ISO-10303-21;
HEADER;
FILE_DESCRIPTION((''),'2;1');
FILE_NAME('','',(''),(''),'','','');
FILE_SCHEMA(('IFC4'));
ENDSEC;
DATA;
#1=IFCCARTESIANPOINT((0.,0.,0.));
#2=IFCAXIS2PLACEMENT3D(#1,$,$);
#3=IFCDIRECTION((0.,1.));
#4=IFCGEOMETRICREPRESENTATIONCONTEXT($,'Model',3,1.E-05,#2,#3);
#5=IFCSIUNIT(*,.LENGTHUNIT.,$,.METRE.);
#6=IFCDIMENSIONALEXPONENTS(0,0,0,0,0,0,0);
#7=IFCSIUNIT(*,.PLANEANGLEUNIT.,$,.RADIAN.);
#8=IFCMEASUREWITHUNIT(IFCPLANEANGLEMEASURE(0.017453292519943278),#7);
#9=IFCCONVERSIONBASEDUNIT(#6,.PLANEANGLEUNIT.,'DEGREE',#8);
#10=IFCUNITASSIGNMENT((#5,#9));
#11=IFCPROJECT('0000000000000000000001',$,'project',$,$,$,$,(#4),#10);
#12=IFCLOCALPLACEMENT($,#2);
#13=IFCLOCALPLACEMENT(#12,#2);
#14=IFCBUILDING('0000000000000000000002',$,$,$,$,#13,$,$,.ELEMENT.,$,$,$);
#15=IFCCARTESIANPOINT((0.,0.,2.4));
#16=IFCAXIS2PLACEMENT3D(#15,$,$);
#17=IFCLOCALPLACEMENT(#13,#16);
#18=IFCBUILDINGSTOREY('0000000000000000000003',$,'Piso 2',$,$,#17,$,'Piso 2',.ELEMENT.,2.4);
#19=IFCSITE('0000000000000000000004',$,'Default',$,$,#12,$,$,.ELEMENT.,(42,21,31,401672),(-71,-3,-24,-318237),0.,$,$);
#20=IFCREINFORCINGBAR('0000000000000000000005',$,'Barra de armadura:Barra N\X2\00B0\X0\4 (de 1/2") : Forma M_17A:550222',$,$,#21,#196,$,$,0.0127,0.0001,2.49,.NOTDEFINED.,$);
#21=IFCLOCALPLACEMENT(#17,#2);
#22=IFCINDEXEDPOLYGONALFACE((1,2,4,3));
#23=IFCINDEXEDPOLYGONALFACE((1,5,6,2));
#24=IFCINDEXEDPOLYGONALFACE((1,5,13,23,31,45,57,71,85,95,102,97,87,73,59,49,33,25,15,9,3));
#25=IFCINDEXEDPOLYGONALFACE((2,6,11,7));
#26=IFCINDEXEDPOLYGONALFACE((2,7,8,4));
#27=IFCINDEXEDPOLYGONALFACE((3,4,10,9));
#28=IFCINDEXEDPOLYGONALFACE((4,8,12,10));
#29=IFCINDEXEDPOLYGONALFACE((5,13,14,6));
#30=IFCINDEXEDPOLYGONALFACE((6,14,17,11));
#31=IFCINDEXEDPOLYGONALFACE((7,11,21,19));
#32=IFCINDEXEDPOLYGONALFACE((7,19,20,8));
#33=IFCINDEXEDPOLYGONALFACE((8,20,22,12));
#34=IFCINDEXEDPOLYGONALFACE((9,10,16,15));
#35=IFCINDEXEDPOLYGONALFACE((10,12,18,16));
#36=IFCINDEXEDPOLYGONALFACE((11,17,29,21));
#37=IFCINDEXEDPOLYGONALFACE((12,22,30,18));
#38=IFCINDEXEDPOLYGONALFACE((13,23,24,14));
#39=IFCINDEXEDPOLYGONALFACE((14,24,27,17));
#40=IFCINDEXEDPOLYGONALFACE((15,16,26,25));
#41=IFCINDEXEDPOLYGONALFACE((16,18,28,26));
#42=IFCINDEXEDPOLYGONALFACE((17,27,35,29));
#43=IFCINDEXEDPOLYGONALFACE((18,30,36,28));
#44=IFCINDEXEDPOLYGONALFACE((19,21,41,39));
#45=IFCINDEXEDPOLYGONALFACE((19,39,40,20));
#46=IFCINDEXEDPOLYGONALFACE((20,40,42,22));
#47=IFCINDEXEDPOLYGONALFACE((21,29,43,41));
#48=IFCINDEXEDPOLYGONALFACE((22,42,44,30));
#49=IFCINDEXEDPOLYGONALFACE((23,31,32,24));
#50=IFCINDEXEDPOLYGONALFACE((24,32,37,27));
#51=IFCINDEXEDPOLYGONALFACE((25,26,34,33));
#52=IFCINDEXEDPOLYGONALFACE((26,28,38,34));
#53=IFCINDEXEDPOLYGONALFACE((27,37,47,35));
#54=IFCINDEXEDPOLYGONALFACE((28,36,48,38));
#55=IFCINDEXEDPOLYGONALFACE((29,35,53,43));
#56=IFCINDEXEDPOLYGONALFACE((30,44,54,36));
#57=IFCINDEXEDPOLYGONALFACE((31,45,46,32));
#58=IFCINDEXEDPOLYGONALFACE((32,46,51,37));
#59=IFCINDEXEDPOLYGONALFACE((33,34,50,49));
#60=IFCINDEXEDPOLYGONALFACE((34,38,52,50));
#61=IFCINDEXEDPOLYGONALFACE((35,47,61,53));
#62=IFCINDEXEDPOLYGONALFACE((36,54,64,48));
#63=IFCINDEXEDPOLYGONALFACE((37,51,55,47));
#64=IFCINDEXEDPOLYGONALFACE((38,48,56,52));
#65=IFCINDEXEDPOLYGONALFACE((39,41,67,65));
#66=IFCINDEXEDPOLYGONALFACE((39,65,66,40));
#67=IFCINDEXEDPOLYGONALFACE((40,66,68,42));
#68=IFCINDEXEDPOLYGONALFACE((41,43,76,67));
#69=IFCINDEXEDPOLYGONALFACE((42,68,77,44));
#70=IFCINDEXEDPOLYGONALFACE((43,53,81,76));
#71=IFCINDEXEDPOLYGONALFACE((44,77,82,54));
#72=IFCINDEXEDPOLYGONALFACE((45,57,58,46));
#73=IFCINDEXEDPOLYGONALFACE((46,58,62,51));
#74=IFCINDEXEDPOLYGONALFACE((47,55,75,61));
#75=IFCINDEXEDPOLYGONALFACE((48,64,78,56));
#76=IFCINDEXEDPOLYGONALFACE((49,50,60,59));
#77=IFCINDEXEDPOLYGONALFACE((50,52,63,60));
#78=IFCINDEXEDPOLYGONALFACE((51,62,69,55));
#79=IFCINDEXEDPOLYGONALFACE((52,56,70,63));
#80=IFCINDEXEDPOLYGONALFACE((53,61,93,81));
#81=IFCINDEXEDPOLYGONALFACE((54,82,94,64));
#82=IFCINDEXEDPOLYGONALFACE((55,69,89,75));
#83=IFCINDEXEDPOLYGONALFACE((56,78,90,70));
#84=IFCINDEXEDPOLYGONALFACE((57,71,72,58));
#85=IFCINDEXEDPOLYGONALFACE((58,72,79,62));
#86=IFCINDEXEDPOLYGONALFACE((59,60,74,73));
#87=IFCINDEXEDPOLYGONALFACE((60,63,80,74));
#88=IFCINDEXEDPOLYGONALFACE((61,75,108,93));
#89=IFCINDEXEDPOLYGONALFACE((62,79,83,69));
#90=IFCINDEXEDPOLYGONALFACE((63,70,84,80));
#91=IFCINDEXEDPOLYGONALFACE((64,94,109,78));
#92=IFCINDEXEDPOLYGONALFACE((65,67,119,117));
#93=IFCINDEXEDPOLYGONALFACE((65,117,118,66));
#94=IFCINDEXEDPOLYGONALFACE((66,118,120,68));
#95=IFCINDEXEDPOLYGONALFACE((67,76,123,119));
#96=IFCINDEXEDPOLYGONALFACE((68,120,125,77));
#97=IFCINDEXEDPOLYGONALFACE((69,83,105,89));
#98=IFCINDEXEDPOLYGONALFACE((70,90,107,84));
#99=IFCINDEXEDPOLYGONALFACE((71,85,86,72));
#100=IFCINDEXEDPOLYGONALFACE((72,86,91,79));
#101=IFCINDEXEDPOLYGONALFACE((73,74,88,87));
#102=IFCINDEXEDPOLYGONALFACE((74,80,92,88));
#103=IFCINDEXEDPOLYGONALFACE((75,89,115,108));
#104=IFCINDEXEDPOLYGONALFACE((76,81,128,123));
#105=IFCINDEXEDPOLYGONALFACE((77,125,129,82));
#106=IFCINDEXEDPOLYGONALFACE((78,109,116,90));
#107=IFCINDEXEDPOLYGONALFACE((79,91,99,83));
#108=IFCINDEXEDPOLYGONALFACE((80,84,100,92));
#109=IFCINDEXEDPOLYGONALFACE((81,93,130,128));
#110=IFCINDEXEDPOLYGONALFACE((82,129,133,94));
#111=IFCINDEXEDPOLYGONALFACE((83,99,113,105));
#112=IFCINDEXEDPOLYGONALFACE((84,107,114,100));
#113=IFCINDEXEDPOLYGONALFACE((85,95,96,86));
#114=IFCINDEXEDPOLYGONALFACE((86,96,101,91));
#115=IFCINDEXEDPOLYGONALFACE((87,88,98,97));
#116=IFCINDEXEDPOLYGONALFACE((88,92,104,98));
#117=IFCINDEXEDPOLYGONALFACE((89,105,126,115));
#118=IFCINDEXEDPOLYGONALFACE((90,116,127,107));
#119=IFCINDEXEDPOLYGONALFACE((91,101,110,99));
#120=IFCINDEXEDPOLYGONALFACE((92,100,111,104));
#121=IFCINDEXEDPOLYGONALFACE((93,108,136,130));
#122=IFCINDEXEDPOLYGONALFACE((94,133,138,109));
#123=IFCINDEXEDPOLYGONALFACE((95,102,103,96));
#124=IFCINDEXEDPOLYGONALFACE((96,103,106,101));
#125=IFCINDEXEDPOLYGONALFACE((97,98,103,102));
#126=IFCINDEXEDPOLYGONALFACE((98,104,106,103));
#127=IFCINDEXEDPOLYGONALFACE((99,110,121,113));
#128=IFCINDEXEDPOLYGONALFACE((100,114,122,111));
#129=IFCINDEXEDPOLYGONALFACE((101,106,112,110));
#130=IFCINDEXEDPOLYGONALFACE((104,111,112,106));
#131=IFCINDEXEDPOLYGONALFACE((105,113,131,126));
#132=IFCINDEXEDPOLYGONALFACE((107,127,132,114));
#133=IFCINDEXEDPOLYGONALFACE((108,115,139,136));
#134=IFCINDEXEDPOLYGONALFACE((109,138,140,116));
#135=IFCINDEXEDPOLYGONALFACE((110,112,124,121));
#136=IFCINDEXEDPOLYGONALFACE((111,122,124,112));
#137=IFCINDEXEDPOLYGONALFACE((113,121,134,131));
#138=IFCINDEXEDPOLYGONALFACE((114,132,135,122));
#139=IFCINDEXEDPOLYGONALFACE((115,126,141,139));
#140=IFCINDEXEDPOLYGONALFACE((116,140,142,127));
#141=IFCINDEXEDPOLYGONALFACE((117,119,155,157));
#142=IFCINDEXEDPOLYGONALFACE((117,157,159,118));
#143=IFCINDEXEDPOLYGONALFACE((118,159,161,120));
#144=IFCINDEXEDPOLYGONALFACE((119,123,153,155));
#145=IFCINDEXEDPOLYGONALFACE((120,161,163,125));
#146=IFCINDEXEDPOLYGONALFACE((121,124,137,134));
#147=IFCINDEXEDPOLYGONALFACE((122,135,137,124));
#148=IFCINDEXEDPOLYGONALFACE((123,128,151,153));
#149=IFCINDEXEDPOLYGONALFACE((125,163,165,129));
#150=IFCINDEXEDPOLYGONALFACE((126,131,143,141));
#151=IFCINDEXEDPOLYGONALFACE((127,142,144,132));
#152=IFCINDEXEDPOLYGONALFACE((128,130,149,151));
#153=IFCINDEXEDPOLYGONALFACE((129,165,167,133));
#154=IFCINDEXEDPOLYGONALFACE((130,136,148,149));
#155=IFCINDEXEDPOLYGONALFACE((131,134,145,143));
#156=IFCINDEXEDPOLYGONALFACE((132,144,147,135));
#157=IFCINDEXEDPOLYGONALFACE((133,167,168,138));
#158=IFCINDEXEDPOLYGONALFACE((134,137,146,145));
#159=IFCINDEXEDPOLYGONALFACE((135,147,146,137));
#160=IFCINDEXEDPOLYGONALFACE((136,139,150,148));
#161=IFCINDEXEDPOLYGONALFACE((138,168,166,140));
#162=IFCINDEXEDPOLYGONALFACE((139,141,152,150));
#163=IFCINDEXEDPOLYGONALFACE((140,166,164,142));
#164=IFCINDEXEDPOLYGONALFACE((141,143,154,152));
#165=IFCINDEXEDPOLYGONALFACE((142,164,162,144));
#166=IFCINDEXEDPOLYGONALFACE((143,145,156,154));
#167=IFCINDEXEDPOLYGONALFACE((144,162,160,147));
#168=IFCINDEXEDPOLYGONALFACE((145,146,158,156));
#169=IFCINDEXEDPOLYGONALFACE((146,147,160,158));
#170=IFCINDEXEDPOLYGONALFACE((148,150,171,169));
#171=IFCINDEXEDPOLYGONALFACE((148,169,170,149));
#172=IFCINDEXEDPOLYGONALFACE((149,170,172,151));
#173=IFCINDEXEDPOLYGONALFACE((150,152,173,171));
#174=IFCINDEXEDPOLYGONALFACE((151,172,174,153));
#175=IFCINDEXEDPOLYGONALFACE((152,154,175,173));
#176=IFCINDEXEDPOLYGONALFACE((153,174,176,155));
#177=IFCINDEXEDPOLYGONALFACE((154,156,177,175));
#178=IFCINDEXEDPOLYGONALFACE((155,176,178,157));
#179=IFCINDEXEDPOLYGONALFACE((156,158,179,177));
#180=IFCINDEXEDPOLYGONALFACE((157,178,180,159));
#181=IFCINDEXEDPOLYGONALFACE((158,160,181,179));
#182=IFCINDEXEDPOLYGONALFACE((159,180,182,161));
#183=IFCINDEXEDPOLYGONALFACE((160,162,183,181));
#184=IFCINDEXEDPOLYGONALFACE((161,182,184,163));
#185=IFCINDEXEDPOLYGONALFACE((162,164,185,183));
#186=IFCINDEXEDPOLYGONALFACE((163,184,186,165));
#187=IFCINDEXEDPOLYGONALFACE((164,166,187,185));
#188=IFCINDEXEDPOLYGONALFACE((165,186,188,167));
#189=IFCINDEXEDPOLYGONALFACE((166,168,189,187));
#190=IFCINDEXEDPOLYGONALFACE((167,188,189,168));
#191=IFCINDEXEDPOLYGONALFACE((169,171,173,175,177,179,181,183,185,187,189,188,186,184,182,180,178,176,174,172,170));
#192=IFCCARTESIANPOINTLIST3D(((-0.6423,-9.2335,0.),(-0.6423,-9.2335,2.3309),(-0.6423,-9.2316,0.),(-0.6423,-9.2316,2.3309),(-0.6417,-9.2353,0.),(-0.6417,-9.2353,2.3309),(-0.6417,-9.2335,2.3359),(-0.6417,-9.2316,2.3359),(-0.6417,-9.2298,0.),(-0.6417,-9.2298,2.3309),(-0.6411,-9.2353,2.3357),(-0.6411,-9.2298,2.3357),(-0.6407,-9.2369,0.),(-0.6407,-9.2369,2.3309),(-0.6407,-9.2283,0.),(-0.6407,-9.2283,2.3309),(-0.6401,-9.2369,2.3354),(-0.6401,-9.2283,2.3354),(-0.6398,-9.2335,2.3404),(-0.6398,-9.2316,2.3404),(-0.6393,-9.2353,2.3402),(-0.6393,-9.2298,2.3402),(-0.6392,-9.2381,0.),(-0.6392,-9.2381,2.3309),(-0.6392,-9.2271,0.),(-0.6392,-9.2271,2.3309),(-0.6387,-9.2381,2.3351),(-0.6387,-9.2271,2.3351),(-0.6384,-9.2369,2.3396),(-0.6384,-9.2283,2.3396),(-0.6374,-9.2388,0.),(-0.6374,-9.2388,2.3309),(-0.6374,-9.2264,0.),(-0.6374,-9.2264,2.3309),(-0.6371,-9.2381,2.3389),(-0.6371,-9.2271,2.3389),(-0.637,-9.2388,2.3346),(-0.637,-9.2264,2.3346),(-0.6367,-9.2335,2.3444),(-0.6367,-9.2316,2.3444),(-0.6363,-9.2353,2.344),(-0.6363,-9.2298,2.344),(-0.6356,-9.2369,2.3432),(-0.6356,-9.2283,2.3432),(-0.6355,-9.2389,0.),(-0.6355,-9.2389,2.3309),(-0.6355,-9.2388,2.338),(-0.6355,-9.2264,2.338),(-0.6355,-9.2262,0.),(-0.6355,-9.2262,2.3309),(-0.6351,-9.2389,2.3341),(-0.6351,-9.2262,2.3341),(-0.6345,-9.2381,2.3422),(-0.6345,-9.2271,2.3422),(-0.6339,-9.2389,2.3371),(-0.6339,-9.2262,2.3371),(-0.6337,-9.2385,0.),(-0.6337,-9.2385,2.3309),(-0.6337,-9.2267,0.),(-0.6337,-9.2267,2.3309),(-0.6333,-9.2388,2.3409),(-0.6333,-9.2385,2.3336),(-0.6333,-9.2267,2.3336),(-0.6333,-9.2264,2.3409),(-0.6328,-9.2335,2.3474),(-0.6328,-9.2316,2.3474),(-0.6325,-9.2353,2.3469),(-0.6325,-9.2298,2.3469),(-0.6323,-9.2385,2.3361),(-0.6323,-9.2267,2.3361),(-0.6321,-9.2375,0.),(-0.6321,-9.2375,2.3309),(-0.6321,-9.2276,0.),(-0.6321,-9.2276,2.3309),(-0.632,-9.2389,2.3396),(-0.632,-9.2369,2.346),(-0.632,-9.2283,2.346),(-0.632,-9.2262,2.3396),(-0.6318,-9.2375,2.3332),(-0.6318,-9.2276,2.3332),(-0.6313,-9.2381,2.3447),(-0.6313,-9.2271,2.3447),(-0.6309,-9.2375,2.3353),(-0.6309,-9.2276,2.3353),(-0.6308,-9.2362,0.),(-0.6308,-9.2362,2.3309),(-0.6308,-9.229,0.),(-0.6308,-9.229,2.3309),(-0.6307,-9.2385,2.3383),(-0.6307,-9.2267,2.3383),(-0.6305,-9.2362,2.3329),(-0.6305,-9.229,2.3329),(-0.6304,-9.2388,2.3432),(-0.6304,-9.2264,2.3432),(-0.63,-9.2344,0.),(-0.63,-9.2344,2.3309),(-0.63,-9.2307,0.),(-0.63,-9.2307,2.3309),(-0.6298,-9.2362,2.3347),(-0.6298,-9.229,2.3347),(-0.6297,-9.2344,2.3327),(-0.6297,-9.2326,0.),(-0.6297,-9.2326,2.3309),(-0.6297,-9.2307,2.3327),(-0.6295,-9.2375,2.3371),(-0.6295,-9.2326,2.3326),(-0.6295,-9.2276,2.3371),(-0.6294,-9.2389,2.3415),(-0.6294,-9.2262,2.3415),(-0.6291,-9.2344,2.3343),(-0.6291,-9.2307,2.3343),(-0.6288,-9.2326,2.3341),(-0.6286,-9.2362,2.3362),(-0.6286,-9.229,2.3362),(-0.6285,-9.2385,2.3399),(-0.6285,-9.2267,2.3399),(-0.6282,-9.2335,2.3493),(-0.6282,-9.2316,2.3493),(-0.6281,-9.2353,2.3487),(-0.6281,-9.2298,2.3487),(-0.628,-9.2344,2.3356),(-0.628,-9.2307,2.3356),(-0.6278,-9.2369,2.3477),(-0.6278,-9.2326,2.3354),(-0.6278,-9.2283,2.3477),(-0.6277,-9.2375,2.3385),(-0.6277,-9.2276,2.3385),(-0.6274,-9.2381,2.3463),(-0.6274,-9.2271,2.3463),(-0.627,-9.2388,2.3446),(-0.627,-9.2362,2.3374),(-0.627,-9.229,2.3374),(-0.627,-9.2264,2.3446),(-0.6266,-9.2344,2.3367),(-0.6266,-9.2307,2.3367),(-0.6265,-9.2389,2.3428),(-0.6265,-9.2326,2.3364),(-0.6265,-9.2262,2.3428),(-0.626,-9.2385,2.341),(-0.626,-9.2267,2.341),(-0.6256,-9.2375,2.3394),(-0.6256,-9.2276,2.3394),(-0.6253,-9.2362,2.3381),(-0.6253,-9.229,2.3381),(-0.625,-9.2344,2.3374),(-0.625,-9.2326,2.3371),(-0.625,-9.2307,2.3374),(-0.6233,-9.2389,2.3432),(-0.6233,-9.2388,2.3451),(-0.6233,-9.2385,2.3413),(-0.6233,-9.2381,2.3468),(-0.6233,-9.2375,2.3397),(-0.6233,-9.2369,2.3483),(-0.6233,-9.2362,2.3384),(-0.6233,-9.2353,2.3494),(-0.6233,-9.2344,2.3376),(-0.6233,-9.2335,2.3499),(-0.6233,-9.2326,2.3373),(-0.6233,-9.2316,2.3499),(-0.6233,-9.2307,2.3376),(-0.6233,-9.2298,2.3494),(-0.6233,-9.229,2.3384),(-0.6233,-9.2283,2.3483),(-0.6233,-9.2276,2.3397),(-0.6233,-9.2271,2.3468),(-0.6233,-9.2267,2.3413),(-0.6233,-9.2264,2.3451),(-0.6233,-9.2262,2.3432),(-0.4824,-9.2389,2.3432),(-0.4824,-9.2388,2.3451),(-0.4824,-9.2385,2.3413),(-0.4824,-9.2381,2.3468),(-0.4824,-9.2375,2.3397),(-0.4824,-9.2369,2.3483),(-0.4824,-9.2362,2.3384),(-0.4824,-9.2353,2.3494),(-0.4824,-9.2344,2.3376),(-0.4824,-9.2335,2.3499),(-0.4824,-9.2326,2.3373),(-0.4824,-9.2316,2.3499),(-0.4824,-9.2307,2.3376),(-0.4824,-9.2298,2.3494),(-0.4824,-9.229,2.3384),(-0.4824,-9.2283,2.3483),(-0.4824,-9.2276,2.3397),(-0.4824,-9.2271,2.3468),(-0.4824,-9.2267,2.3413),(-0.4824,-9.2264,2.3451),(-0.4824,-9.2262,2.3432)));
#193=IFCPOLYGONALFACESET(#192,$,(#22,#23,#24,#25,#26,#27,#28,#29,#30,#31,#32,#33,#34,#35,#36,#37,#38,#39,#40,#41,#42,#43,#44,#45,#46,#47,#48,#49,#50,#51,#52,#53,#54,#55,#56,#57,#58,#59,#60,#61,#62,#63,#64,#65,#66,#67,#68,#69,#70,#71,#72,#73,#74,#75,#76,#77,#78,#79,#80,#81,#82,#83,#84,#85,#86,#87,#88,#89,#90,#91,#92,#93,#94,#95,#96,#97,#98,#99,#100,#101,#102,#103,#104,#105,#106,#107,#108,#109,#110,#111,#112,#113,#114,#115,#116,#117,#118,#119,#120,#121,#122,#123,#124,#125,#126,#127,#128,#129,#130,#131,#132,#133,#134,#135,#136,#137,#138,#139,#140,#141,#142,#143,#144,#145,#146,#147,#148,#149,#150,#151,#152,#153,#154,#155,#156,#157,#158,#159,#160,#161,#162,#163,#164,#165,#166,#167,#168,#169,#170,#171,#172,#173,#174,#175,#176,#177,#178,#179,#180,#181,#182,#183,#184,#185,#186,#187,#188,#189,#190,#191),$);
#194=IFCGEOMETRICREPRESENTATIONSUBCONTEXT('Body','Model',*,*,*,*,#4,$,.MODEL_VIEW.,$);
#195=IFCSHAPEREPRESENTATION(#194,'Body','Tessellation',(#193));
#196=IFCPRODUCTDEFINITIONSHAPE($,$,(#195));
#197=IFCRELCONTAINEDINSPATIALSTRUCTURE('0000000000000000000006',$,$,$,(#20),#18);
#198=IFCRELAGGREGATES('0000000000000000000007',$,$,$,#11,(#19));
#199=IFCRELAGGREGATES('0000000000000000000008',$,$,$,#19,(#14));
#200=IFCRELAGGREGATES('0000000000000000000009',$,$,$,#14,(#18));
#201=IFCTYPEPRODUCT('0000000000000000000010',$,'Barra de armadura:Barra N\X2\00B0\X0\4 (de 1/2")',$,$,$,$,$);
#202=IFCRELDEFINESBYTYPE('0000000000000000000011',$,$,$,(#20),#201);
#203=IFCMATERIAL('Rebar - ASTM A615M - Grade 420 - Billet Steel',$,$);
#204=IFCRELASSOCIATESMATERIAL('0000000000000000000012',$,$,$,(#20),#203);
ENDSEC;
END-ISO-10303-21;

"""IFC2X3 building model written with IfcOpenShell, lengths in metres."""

from ifc_helpers import new_model, entity, si_unit, converted_unit, direction, frame, origin, place, context, subcontext, project, spatial, material, type_object, element, save


model = new_model("IFC2X3")

# Units and contexts
model_context = context("Model", 3, precision=1e-05, world=origin(), true_north=direction((0.0, 1.0)))
body_context = subcontext(model_context, "Body", "Model", "MODEL_VIEW")
ifc_project = project(units=[si_unit("LENGTHUNIT", "METRE"), converted_unit("PLANEANGLEUNIT", "DEGREE", entity("IfcPlaneAngleMeasure", 0.017453292519943278), si_unit("PLANEANGLEUNIT", "RADIAN"), dimensions=[0, 0, 0, 0, 0, 0, 0])], contexts=[model_context])

# Site, building, storey
site_placement = place(None, origin())
site = spatial("IfcSite", under=ifc_project, at=site_placement, Name="Default", CompositionType="ELEMENT", RefLatitude=(42, 21, 31, 401672), RefLongitude=(-71, -3, -24, -318237), RefElevation=0.0)
building_placement = place(site_placement, origin())
building = spatial("IfcBuilding", under=site, at=building_placement, CompositionType="ELEMENT")
storey_placement = place(building_placement, frame((0.0, 0.0, 2.4)))
storey = spatial("IfcBuildingStorey", under=building, at=storey_placement, Name="Piso 2", LongName="Piso 2", CompositionType="ELEMENT", Elevation=2.4)

# Reinforcing bar
ifc_material_1 = material(Name="Rebar - ASTM A615M - Grade 420 - Billet Steel")
type_product = type_object("IfcTypeProduct", Name="Barra de armadura:Barra N°4 (de 1/2\")")
reinforcing_bar_1_placement = place(storey_placement, origin())
element("IfcReinforcingBar", 1, at=reinforcing_bar_1_placement, inside=storey, type_object=type_product, material=ifc_material_1, Name="Barra de armadura:Barra N°4 (de 1/2\") : Forma M_17A:550222", BarLength=2.49, BarRole="NOTDEFINED", CrossSectionArea=0.0001, NominalDiameter=0.0127, context=body_context, shape_type="AdvancedSweptSolid", body=[
    entity("IfcSweptDiskSolid", entity("IfcCompositeCurve", [entity("IfcCompositeCurveSegment", "CONTINUOUS", True, entity("IfcPolyline", [entity("IfcCartesianPoint", [-0.636, -9.2326, 0.0]), entity("IfcCartesianPoint", [-0.636, -9.2326, 2.3309])])), entity("IfcCompositeCurveSegment", "CONTINUOUS", True, entity("IfcTrimmedCurve", entity("IfcCircle", entity("IfcAxis2Placement3D", entity("IfcCartesianPoint", [-0.6233, -9.2326, 2.3309]), entity("IfcDirection", [0.0, 1.0, 0.0]), entity("IfcDirection", [0.0, 0.0, 1.0])), 0.0127), [entity("IfcParameterValue", 270.0)], [entity("IfcParameterValue", 360.0)], True, "PARAMETER")), entity("IfcCompositeCurveSegment", "CONTINUOUS", True, entity("IfcPolyline", [entity("IfcCartesianPoint", [-0.6233, -9.2326, 2.3436]), entity("IfcCartesianPoint", [-0.4824, -9.2326, 2.3436])]))], False), 0.0063, None, 0.0, 92.0),
])

save(model, "model.ifc")
